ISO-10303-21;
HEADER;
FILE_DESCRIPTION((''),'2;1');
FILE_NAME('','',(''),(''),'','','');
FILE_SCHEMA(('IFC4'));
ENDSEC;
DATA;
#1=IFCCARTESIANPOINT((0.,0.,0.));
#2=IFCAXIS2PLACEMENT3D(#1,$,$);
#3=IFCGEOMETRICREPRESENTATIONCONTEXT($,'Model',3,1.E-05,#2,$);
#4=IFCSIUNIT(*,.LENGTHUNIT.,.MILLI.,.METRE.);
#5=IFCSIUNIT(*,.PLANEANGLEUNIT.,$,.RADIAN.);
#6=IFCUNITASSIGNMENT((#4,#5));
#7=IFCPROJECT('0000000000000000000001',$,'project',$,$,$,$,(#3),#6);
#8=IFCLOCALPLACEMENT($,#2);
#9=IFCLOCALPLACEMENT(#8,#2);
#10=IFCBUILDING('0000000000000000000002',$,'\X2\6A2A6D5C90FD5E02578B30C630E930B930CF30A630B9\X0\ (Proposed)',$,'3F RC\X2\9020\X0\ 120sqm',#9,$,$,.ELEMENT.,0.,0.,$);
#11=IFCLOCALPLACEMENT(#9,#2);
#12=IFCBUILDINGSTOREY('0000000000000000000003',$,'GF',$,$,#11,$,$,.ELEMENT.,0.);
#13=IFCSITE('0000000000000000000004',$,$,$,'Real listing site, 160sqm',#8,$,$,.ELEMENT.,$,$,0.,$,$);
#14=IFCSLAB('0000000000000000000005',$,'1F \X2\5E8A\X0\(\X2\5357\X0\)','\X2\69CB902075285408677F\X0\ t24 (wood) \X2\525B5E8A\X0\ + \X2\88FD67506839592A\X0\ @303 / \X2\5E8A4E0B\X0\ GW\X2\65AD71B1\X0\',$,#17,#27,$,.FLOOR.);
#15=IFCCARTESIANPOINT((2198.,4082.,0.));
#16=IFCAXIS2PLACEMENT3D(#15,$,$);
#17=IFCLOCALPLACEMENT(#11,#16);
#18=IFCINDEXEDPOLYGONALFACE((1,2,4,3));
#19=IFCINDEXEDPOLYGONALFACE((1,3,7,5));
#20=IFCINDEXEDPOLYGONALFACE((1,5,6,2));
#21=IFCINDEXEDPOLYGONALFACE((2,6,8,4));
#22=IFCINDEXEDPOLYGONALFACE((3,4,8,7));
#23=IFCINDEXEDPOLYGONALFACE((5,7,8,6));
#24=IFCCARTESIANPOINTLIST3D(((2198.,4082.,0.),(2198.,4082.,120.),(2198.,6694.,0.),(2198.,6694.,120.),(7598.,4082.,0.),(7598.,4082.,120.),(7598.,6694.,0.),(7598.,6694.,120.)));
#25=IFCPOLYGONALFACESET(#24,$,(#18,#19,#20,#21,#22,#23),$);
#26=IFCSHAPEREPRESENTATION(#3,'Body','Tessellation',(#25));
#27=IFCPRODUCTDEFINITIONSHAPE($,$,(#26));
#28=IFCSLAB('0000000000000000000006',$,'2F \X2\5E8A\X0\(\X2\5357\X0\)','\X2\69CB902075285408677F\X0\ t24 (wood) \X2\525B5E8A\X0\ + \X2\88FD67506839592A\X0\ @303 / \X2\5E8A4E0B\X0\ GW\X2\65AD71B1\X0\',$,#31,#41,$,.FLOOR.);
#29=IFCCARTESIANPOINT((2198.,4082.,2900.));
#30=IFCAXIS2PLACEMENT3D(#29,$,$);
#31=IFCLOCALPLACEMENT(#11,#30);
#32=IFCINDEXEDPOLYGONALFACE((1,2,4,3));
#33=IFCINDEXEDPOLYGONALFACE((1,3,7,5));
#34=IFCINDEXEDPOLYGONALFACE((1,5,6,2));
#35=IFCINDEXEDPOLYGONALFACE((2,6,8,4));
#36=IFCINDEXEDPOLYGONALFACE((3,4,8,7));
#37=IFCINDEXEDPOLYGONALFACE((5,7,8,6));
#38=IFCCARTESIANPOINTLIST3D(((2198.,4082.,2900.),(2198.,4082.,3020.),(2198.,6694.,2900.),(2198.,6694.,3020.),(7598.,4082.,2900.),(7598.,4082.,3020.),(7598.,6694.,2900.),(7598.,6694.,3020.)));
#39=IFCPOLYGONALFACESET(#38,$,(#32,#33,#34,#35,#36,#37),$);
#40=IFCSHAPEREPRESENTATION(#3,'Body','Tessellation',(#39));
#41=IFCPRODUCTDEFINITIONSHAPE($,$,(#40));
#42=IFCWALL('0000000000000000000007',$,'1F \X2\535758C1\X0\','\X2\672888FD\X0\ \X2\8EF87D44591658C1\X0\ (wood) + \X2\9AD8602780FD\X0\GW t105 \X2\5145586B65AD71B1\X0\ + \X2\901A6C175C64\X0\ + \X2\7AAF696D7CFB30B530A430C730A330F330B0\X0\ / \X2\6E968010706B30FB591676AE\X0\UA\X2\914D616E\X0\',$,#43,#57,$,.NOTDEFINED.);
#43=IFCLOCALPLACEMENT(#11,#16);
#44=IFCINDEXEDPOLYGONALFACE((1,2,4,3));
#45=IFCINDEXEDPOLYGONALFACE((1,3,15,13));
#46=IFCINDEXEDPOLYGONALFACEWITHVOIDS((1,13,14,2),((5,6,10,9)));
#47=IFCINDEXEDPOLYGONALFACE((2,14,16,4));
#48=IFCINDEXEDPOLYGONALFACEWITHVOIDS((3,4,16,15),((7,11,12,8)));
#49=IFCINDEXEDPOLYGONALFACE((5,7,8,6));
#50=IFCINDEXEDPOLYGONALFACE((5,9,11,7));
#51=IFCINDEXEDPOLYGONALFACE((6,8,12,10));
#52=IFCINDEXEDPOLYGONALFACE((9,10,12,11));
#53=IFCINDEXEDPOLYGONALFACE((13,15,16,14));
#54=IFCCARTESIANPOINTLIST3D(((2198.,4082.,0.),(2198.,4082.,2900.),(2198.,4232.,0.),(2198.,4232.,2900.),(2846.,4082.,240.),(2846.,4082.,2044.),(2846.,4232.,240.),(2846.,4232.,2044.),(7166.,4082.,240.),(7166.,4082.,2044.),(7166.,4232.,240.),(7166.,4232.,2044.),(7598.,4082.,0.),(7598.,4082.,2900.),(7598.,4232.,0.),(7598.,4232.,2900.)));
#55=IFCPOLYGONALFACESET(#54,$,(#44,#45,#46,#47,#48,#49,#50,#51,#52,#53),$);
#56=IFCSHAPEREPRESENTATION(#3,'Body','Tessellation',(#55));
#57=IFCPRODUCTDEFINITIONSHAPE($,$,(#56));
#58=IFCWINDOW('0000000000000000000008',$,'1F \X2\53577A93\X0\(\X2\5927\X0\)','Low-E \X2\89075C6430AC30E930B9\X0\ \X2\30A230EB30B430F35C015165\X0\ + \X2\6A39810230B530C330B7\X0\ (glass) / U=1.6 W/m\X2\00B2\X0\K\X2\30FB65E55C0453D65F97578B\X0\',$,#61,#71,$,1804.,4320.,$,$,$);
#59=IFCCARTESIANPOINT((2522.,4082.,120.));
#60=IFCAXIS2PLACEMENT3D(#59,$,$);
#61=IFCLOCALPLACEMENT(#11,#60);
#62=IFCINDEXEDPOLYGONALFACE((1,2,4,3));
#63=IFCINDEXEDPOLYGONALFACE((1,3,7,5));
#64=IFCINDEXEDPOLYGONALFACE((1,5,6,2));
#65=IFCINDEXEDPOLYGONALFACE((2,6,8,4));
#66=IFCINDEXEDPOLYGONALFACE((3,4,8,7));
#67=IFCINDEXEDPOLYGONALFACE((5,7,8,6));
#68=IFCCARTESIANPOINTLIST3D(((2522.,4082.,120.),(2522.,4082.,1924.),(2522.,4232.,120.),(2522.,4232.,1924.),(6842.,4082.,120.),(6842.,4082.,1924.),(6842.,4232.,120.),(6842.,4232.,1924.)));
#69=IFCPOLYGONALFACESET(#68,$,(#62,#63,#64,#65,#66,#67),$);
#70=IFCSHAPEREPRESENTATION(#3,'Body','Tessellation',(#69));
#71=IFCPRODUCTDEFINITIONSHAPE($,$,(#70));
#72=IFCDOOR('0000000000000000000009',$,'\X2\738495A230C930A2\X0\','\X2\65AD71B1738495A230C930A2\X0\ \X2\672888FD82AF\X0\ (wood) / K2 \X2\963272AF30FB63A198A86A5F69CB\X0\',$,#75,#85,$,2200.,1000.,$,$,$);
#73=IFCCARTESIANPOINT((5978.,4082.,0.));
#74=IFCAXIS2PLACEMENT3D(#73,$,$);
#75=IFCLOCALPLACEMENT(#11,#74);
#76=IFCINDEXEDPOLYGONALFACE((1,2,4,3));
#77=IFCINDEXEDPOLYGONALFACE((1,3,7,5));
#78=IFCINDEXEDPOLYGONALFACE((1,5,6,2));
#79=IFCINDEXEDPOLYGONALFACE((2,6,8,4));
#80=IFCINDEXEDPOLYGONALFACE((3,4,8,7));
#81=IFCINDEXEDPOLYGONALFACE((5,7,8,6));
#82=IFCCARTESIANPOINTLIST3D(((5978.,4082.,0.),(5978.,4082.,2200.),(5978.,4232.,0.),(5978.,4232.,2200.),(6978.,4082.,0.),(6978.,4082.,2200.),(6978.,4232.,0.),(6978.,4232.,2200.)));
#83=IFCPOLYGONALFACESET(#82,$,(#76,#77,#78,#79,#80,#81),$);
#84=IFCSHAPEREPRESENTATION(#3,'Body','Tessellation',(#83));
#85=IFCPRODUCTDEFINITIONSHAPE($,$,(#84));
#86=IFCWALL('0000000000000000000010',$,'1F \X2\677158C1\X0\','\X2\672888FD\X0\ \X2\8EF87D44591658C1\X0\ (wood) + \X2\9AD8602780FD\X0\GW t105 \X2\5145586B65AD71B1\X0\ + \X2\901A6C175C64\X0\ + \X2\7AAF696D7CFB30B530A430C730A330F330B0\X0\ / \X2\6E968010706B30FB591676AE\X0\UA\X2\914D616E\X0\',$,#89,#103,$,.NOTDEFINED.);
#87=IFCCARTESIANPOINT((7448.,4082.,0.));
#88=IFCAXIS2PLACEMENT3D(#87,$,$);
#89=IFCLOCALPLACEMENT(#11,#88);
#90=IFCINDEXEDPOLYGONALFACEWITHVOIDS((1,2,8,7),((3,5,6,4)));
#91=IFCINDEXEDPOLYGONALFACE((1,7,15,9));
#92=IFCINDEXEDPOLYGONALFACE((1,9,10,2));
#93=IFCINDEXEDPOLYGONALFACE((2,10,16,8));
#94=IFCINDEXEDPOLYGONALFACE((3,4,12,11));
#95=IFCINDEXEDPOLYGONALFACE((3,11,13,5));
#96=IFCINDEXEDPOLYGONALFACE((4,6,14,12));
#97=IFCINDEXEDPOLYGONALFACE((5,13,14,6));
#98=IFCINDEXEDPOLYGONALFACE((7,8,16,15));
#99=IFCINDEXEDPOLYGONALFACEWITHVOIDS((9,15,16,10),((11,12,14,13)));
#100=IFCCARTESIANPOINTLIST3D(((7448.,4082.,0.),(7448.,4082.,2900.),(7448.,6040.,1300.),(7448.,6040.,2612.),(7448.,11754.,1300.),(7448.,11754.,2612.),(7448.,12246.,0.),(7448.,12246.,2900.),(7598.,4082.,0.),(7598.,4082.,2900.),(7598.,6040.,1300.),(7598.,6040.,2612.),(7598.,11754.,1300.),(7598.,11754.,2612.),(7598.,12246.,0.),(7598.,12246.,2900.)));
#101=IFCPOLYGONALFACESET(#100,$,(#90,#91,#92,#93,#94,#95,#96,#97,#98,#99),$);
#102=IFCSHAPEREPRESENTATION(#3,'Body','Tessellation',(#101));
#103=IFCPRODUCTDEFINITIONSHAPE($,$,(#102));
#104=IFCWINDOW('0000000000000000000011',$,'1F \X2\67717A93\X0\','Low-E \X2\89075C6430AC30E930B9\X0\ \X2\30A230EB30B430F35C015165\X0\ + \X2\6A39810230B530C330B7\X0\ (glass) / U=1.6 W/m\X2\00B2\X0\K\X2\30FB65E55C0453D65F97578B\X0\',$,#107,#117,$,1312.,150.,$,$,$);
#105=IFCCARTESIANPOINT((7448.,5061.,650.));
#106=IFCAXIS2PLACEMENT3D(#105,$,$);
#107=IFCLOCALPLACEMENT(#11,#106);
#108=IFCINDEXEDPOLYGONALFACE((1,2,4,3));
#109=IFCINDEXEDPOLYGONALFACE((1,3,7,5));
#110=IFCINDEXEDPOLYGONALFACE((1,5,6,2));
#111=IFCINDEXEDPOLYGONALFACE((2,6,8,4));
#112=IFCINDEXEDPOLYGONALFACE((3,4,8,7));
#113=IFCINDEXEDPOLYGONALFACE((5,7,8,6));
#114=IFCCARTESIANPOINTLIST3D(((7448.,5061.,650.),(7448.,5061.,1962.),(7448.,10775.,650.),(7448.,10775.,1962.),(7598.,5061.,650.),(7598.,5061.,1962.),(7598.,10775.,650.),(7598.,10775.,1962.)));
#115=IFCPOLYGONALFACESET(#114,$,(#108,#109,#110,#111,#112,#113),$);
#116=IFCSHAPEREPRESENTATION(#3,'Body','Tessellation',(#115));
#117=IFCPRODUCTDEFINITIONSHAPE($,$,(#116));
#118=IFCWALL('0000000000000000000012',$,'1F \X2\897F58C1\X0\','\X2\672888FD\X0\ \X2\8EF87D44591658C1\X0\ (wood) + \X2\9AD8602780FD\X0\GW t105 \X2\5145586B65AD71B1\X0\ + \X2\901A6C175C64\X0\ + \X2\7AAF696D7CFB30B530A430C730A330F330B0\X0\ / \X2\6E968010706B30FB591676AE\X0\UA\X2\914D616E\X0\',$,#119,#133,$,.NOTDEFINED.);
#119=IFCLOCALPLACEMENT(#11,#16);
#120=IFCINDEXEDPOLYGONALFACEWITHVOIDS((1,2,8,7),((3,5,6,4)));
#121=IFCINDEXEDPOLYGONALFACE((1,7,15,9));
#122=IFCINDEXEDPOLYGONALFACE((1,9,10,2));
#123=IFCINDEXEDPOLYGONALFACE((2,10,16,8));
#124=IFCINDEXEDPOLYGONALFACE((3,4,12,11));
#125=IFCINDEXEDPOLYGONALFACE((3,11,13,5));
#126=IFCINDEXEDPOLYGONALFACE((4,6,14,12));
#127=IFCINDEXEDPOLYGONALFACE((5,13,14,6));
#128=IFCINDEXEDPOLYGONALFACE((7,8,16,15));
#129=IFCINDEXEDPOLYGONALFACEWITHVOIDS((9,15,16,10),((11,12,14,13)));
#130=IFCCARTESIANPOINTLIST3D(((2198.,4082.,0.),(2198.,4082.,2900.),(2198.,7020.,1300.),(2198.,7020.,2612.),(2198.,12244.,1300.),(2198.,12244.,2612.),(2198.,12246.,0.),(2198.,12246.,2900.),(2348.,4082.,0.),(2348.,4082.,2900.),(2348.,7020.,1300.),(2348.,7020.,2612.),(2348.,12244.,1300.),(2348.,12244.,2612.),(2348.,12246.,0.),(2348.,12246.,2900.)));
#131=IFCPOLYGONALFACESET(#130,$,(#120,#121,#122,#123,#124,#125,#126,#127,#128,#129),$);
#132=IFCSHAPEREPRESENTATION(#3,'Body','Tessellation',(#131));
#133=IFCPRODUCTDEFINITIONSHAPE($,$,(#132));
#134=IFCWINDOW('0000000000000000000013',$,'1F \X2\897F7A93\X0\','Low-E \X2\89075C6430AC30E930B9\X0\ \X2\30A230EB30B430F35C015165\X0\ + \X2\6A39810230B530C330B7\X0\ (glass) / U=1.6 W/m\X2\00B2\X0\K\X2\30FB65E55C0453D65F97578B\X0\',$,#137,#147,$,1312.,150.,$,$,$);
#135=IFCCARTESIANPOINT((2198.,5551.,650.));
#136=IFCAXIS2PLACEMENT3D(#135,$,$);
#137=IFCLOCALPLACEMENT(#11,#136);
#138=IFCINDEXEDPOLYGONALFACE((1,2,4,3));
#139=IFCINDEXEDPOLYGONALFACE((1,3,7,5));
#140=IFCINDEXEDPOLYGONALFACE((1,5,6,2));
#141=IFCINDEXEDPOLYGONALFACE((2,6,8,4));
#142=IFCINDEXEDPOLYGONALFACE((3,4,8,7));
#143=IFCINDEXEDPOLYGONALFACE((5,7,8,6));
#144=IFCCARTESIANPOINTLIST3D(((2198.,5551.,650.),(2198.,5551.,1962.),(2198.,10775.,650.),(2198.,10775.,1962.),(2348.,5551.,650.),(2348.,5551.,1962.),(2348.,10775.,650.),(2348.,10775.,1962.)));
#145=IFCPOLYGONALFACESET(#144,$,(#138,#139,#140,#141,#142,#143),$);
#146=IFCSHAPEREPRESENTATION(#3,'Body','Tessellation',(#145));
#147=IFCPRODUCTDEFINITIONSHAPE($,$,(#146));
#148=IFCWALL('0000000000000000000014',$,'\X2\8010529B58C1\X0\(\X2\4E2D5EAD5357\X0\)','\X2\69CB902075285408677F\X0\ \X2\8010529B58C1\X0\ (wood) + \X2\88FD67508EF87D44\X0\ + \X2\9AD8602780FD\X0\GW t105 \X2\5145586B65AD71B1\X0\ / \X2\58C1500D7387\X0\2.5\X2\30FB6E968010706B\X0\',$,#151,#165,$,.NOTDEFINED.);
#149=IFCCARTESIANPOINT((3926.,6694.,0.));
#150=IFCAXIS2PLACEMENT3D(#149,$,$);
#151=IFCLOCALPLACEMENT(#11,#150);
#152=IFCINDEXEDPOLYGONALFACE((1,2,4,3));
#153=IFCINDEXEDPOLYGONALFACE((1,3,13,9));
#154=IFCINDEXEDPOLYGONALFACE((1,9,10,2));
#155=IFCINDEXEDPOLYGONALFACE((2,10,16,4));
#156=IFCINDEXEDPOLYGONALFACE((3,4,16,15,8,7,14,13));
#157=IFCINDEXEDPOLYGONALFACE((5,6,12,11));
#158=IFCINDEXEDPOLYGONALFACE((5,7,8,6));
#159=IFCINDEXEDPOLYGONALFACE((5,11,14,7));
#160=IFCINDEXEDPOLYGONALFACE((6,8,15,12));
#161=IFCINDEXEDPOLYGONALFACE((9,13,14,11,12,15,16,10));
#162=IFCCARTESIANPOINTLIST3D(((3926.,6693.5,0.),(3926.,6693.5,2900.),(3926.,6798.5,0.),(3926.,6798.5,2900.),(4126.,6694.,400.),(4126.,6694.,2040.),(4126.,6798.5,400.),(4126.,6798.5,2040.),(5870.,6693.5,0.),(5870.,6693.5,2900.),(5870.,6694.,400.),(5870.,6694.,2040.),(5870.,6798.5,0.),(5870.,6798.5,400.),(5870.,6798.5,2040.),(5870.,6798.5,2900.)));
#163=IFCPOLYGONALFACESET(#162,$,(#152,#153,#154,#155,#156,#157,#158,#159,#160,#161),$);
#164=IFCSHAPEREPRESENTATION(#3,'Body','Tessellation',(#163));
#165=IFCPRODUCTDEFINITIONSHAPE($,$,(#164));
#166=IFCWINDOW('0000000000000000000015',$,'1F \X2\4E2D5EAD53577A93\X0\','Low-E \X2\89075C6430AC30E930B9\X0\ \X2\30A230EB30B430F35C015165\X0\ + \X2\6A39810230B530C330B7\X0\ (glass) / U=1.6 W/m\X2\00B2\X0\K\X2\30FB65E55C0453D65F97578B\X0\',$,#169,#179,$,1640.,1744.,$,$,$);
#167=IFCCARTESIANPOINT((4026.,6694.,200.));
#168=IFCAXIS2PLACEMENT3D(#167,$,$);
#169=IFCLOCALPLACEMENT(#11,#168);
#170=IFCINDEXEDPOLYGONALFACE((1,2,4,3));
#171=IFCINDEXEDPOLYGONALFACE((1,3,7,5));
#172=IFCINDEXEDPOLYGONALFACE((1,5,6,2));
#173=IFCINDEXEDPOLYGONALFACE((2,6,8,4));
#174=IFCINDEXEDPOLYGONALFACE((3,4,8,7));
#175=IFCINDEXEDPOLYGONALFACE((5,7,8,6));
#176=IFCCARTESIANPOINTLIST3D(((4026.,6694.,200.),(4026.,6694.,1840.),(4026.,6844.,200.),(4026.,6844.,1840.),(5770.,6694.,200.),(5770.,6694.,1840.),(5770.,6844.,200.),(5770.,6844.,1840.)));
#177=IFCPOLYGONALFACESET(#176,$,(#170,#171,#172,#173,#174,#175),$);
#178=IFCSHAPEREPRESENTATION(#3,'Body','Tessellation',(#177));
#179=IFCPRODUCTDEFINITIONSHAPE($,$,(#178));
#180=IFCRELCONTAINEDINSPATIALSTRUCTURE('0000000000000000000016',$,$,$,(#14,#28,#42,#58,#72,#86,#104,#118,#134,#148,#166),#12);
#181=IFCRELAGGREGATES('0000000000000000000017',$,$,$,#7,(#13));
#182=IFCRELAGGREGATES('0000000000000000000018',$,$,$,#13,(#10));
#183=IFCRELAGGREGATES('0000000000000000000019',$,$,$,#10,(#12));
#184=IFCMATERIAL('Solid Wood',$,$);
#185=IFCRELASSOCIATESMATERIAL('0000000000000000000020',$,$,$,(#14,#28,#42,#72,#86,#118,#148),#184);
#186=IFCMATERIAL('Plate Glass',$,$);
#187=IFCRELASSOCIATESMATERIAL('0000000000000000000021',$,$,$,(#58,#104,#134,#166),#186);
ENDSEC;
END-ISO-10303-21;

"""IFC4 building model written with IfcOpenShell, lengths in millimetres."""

from ifc_helpers import new_model, si_unit, frame, frame_2d, origin, place, context, project, spatial, rectangle, extrude, material, element, fill, save


model = new_model("IFC4")

# Units and contexts
model_context = context("Model", 3, precision=1e-05, world=origin())
ifc_project = project(units=[si_unit("LENGTHUNIT", "METRE", prefix="MILLI"), si_unit("PLANEANGLEUNIT", "RADIAN")], contexts=[model_context])

# Site, building, storey
site_placement = place(None, origin())
site = spatial("IfcSite", under=ifc_project, at=site_placement, ObjectType="Real listing site, 160sqm", CompositionType="ELEMENT", RefElevation=0.0)
building_placement = place(site_placement, origin())
building = spatial("IfcBuilding", under=site, at=building_placement, Name="横浜都市型テラスハウス (Proposed)", ObjectType="3F RC造 120sqm", CompositionType="ELEMENT", ElevationOfRefHeight=0.0, ElevationOfTerrain=0.0)
storey_placement = place(building_placement, origin())
storey = spatial("IfcBuildingStorey", under=building, at=storey_placement, Name="GF", CompositionType="ELEMENT", Elevation=0.0)

# Slabs
ifc_material_1 = material(Name="Solid Wood")
slab_1_placement = place(storey_placement, frame((2198.0, 4082.0, 0.0)))
element("IfcSlab", 1, at=slab_1_placement, inside=storey, material=ifc_material_1, Name="1F 床(南)", Description="構造用合板 t24 (wood) 剛床 + 製材根太 @303 / 床下 GW断熱", PredefinedType="FLOOR", context=model_context, shape_type="SweptSolid", body=[
    extrude(rectangle(XDim=5400.0, YDim=2612.0, at=frame_2d((2700.0, 1306.0))), frame((2198.0, 4082.0, 0.0)), (0.0, 0.0, 1.0), 120.0),
])
slab_2_placement = place(storey_placement, frame((2198.0, 4082.0, 2900.0)))
element("IfcSlab", 2, at=slab_2_placement, inside=storey, material=ifc_material_1, Name="2F 床(南)", Description="構造用合板 t24 (wood) 剛床 + 製材根太 @303 / 床下 GW断熱", PredefinedType="FLOOR", context=model_context, shape_type="SweptSolid", body=[
    extrude(rectangle(XDim=5400.0, YDim=2612.0, at=frame_2d((2700.0, 1306.0))), frame((2198.0, 4082.0, 2900.0)), (0.0, 0.0, 1.0), 120.0),
])

# Wall, openings, window, door
wall_1_placement = place(storey_placement, frame((2198.0, 4082.0, 0.0)))
wall_1 = element("IfcWall", 3, at=wall_1_placement, inside=storey, material=ifc_material_1, Name="1F 南壁", Description="木製 軸組外壁 (wood) + 高性能GW t105 充填断熱 + 通気層 + 窯業系サイディング / 準耐火・外皮UA配慮", PredefinedType="NOTDEFINED", context=model_context, shape_type="SweptSolid", body=[
    extrude(rectangle(XDim=5400.0, YDim=150.0, at=frame_2d((2700.0, 75.0))), frame((2198.0, 4082.0, 0.0)), (0.0, 0.0, 1.0), 2900.0),
])
opening_1_placement = place(storey_placement, frame((2522.0, 4082.0, 120.0)))
opening_1 = element("IfcOpeningElement", 4, at=opening_1_placement, cuts=wall_1, PredefinedType="NOTDEFINED", context=model_context, shape_type="SweptSolid", body=[
    extrude(rectangle(XDim=4320.0, YDim=150.0, at=frame_2d((2160.0, 75.0))), frame((2522.0, 4082.0, 120.0)), (0.0, 0.0, 1.0), 1804.0),
])
opening_2_placement = place(storey_placement, frame((5978.0, 4082.0, 0.0)))
opening_2 = element("IfcOpeningElement", 5, at=opening_2_placement, cuts=wall_1, PredefinedType="NOTDEFINED", context=model_context, shape_type="SweptSolid", body=[
    extrude(rectangle(XDim=1000.0, YDim=150.0, at=frame_2d((500.0, 75.0))), frame((5978.0, 4082.0, 0.0)), (0.0, 0.0, 1.0), 2200.0),
])
ifc_material_2 = material(Name="Plate Glass")
window_1_placement = place(storey_placement, frame((2522.0, 4082.0, 120.0)))
window_1 = element("IfcWindow", 6, at=window_1_placement, inside=storey, material=ifc_material_2, Name="1F 南窓(大)", Description="Low-E 複層ガラス アルゴン封入 + 樹脂サッシ (glass) / U=1.6 W/m²K・日射取得型", OverallHeight=1804.0, OverallWidth=4320.0, context=model_context, shape_type="SweptSolid", body=[
    extrude(rectangle(XDim=4320.0, YDim=150.0, at=frame_2d((2160.0, 75.0))), frame((2522.0, 4082.0, 120.0)), (0.0, 0.0, 1.0), 1804.0),
])
fill(opening_1, window_1)
door_placement = place(storey_placement, frame((5978.0, 4082.0, 0.0)))
door = element("IfcDoor", 7, at=door_placement, inside=storey, material=ifc_material_1, Name="玄関ドア", Description="断熱玄関ドア 木製芯 (wood) / K2 防犯・採風機構", OverallHeight=2200.0, OverallWidth=1000.0, context=model_context, shape_type="SweptSolid", body=[
    extrude(rectangle(XDim=1000.0, YDim=150.0, at=frame_2d((500.0, 75.0))), frame((5978.0, 4082.0, 0.0)), (0.0, 0.0, 1.0), 2200.0),
])
fill(opening_2, door)

# Walls, openings, windows
wall_2_placement = place(storey_placement, frame((7448.0, 4082.0, 0.0)))
wall_2 = element("IfcWall", 8, at=wall_2_placement, inside=storey, material=ifc_material_1, Name="1F 東壁", Description="木製 軸組外壁 (wood) + 高性能GW t105 充填断熱 + 通気層 + 窯業系サイディング / 準耐火・外皮UA配慮", PredefinedType="NOTDEFINED", context=model_context, shape_type="SweptSolid", body=[
    extrude(rectangle(XDim=150.0, YDim=8164.0, at=frame_2d((75.0, 4082.0))), frame((7448.0, 4082.0, 0.0)), (0.0, 0.0, 1.0), 2900.0),
])
opening_3_placement = place(storey_placement, frame((7448.0, 5061.0, 650.0)))
opening_3 = element("IfcOpeningElement", 9, at=opening_3_placement, cuts=wall_2, PredefinedType="NOTDEFINED", context=model_context, shape_type="SweptSolid", body=[
    extrude(rectangle(XDim=150.0, YDim=5714.0, at=frame_2d((75.0, 2857.0))), frame((7448.0, 5061.0, 650.0)), (0.0, 0.0, 1.0), 1312.0),
])
window_2_placement = place(storey_placement, frame((7448.0, 5061.0, 650.0)))
window_2 = element("IfcWindow", 10, at=window_2_placement, inside=storey, material=ifc_material_2, Name="1F 東窓", Description="Low-E 複層ガラス アルゴン封入 + 樹脂サッシ (glass) / U=1.6 W/m²K・日射取得型", OverallHeight=1312.0, OverallWidth=150.0, context=model_context, shape_type="SweptSolid", body=[
    extrude(rectangle(XDim=150.0, YDim=5714.0, at=frame_2d((75.0, 2857.0))), frame((7448.0, 5061.0, 650.0)), (0.0, 0.0, 1.0), 1312.0),
])
fill(opening_3, window_2)
wall_3_placement = place(storey_placement, frame((2198.0, 4082.0, 0.0)))
wall_3 = element("IfcWall", 11, at=wall_3_placement, inside=storey, material=ifc_material_1, Name="1F 西壁", Description="木製 軸組外壁 (wood) + 高性能GW t105 充填断熱 + 通気層 + 窯業系サイディング / 準耐火・外皮UA配慮", PredefinedType="NOTDEFINED", context=model_context, shape_type="SweptSolid", body=[
    extrude(rectangle(XDim=150.0, YDim=8164.0, at=frame_2d((75.0, 4082.0))), frame((2198.0, 4082.0, 0.0)), (0.0, 0.0, 1.0), 2900.0),
])
opening_4_placement = place(storey_placement, frame((2198.0, 5551.0, 650.0)))
opening_4 = element("IfcOpeningElement", 12, at=opening_4_placement, cuts=wall_3, PredefinedType="NOTDEFINED", context=model_context, shape_type="SweptSolid", body=[
    extrude(rectangle(XDim=150.0, YDim=5224.0, at=frame_2d((75.0, 2612.0))), frame((2198.0, 5551.0, 650.0)), (0.0, 0.0, 1.0), 1312.0),
])
window_3_placement = place(storey_placement, frame((2198.0, 5551.0, 650.0)))
window_3 = element("IfcWindow", 13, at=window_3_placement, inside=storey, material=ifc_material_2, Name="1F 西窓", Description="Low-E 複層ガラス アルゴン封入 + 樹脂サッシ (glass) / U=1.6 W/m²K・日射取得型", OverallHeight=1312.0, OverallWidth=150.0, context=model_context, shape_type="SweptSolid", body=[
    extrude(rectangle(XDim=150.0, YDim=5224.0, at=frame_2d((75.0, 2612.0))), frame((2198.0, 5551.0, 650.0)), (0.0, 0.0, 1.0), 1312.0),
])
fill(opening_4, window_3)
wall_4_placement = place(storey_placement, frame((3926.0, 6694.0, 0.0)))
wall_4 = element("IfcWall", 14, at=wall_4_placement, inside=storey, material=ifc_material_1, Name="耐力壁(中庭南)", Description="構造用合板 耐力壁 (wood) + 製材軸組 + 高性能GW t105 充填断熱 / 壁倍率2.5・準耐火", PredefinedType="NOTDEFINED", context=model_context, shape_type="SweptSolid", body=[
    extrude(rectangle(XDim=1944.0, YDim=105.0, at=frame_2d((972.0, 52.0))), frame((3926.0, 6694.0, 0.0)), (0.0, 0.0, 1.0), 2900.0),
])
opening_5_placement = place(storey_placement, frame((4026.0, 6694.0, 200.0)))
opening_5 = element("IfcOpeningElement", 15, at=opening_5_placement, cuts=wall_4, PredefinedType="NOTDEFINED", context=model_context, shape_type="SweptSolid", body=[
    extrude(rectangle(XDim=1744.0, YDim=150.0, at=frame_2d((872.0, 75.0))), frame((4026.0, 6694.0, 200.0)), (0.0, 0.0, 1.0), 1640.0),
])
window_4_placement = place(storey_placement, frame((4026.0, 6694.0, 200.0)))
window_4 = element("IfcWindow", 16, at=window_4_placement, inside=storey, material=ifc_material_2, Name="1F 中庭南窓", Description="Low-E 複層ガラス アルゴン封入 + 樹脂サッシ (glass) / U=1.6 W/m²K・日射取得型", OverallHeight=1640.0, OverallWidth=1744.0, context=model_context, shape_type="SweptSolid", body=[
    extrude(rectangle(XDim=1744.0, YDim=150.0, at=frame_2d((872.0, 75.0))), frame((4026.0, 6694.0, 200.0)), (0.0, 0.0, 1.0), 1640.0),
])
fill(opening_5, window_4)

save(model, "model.ifc")
